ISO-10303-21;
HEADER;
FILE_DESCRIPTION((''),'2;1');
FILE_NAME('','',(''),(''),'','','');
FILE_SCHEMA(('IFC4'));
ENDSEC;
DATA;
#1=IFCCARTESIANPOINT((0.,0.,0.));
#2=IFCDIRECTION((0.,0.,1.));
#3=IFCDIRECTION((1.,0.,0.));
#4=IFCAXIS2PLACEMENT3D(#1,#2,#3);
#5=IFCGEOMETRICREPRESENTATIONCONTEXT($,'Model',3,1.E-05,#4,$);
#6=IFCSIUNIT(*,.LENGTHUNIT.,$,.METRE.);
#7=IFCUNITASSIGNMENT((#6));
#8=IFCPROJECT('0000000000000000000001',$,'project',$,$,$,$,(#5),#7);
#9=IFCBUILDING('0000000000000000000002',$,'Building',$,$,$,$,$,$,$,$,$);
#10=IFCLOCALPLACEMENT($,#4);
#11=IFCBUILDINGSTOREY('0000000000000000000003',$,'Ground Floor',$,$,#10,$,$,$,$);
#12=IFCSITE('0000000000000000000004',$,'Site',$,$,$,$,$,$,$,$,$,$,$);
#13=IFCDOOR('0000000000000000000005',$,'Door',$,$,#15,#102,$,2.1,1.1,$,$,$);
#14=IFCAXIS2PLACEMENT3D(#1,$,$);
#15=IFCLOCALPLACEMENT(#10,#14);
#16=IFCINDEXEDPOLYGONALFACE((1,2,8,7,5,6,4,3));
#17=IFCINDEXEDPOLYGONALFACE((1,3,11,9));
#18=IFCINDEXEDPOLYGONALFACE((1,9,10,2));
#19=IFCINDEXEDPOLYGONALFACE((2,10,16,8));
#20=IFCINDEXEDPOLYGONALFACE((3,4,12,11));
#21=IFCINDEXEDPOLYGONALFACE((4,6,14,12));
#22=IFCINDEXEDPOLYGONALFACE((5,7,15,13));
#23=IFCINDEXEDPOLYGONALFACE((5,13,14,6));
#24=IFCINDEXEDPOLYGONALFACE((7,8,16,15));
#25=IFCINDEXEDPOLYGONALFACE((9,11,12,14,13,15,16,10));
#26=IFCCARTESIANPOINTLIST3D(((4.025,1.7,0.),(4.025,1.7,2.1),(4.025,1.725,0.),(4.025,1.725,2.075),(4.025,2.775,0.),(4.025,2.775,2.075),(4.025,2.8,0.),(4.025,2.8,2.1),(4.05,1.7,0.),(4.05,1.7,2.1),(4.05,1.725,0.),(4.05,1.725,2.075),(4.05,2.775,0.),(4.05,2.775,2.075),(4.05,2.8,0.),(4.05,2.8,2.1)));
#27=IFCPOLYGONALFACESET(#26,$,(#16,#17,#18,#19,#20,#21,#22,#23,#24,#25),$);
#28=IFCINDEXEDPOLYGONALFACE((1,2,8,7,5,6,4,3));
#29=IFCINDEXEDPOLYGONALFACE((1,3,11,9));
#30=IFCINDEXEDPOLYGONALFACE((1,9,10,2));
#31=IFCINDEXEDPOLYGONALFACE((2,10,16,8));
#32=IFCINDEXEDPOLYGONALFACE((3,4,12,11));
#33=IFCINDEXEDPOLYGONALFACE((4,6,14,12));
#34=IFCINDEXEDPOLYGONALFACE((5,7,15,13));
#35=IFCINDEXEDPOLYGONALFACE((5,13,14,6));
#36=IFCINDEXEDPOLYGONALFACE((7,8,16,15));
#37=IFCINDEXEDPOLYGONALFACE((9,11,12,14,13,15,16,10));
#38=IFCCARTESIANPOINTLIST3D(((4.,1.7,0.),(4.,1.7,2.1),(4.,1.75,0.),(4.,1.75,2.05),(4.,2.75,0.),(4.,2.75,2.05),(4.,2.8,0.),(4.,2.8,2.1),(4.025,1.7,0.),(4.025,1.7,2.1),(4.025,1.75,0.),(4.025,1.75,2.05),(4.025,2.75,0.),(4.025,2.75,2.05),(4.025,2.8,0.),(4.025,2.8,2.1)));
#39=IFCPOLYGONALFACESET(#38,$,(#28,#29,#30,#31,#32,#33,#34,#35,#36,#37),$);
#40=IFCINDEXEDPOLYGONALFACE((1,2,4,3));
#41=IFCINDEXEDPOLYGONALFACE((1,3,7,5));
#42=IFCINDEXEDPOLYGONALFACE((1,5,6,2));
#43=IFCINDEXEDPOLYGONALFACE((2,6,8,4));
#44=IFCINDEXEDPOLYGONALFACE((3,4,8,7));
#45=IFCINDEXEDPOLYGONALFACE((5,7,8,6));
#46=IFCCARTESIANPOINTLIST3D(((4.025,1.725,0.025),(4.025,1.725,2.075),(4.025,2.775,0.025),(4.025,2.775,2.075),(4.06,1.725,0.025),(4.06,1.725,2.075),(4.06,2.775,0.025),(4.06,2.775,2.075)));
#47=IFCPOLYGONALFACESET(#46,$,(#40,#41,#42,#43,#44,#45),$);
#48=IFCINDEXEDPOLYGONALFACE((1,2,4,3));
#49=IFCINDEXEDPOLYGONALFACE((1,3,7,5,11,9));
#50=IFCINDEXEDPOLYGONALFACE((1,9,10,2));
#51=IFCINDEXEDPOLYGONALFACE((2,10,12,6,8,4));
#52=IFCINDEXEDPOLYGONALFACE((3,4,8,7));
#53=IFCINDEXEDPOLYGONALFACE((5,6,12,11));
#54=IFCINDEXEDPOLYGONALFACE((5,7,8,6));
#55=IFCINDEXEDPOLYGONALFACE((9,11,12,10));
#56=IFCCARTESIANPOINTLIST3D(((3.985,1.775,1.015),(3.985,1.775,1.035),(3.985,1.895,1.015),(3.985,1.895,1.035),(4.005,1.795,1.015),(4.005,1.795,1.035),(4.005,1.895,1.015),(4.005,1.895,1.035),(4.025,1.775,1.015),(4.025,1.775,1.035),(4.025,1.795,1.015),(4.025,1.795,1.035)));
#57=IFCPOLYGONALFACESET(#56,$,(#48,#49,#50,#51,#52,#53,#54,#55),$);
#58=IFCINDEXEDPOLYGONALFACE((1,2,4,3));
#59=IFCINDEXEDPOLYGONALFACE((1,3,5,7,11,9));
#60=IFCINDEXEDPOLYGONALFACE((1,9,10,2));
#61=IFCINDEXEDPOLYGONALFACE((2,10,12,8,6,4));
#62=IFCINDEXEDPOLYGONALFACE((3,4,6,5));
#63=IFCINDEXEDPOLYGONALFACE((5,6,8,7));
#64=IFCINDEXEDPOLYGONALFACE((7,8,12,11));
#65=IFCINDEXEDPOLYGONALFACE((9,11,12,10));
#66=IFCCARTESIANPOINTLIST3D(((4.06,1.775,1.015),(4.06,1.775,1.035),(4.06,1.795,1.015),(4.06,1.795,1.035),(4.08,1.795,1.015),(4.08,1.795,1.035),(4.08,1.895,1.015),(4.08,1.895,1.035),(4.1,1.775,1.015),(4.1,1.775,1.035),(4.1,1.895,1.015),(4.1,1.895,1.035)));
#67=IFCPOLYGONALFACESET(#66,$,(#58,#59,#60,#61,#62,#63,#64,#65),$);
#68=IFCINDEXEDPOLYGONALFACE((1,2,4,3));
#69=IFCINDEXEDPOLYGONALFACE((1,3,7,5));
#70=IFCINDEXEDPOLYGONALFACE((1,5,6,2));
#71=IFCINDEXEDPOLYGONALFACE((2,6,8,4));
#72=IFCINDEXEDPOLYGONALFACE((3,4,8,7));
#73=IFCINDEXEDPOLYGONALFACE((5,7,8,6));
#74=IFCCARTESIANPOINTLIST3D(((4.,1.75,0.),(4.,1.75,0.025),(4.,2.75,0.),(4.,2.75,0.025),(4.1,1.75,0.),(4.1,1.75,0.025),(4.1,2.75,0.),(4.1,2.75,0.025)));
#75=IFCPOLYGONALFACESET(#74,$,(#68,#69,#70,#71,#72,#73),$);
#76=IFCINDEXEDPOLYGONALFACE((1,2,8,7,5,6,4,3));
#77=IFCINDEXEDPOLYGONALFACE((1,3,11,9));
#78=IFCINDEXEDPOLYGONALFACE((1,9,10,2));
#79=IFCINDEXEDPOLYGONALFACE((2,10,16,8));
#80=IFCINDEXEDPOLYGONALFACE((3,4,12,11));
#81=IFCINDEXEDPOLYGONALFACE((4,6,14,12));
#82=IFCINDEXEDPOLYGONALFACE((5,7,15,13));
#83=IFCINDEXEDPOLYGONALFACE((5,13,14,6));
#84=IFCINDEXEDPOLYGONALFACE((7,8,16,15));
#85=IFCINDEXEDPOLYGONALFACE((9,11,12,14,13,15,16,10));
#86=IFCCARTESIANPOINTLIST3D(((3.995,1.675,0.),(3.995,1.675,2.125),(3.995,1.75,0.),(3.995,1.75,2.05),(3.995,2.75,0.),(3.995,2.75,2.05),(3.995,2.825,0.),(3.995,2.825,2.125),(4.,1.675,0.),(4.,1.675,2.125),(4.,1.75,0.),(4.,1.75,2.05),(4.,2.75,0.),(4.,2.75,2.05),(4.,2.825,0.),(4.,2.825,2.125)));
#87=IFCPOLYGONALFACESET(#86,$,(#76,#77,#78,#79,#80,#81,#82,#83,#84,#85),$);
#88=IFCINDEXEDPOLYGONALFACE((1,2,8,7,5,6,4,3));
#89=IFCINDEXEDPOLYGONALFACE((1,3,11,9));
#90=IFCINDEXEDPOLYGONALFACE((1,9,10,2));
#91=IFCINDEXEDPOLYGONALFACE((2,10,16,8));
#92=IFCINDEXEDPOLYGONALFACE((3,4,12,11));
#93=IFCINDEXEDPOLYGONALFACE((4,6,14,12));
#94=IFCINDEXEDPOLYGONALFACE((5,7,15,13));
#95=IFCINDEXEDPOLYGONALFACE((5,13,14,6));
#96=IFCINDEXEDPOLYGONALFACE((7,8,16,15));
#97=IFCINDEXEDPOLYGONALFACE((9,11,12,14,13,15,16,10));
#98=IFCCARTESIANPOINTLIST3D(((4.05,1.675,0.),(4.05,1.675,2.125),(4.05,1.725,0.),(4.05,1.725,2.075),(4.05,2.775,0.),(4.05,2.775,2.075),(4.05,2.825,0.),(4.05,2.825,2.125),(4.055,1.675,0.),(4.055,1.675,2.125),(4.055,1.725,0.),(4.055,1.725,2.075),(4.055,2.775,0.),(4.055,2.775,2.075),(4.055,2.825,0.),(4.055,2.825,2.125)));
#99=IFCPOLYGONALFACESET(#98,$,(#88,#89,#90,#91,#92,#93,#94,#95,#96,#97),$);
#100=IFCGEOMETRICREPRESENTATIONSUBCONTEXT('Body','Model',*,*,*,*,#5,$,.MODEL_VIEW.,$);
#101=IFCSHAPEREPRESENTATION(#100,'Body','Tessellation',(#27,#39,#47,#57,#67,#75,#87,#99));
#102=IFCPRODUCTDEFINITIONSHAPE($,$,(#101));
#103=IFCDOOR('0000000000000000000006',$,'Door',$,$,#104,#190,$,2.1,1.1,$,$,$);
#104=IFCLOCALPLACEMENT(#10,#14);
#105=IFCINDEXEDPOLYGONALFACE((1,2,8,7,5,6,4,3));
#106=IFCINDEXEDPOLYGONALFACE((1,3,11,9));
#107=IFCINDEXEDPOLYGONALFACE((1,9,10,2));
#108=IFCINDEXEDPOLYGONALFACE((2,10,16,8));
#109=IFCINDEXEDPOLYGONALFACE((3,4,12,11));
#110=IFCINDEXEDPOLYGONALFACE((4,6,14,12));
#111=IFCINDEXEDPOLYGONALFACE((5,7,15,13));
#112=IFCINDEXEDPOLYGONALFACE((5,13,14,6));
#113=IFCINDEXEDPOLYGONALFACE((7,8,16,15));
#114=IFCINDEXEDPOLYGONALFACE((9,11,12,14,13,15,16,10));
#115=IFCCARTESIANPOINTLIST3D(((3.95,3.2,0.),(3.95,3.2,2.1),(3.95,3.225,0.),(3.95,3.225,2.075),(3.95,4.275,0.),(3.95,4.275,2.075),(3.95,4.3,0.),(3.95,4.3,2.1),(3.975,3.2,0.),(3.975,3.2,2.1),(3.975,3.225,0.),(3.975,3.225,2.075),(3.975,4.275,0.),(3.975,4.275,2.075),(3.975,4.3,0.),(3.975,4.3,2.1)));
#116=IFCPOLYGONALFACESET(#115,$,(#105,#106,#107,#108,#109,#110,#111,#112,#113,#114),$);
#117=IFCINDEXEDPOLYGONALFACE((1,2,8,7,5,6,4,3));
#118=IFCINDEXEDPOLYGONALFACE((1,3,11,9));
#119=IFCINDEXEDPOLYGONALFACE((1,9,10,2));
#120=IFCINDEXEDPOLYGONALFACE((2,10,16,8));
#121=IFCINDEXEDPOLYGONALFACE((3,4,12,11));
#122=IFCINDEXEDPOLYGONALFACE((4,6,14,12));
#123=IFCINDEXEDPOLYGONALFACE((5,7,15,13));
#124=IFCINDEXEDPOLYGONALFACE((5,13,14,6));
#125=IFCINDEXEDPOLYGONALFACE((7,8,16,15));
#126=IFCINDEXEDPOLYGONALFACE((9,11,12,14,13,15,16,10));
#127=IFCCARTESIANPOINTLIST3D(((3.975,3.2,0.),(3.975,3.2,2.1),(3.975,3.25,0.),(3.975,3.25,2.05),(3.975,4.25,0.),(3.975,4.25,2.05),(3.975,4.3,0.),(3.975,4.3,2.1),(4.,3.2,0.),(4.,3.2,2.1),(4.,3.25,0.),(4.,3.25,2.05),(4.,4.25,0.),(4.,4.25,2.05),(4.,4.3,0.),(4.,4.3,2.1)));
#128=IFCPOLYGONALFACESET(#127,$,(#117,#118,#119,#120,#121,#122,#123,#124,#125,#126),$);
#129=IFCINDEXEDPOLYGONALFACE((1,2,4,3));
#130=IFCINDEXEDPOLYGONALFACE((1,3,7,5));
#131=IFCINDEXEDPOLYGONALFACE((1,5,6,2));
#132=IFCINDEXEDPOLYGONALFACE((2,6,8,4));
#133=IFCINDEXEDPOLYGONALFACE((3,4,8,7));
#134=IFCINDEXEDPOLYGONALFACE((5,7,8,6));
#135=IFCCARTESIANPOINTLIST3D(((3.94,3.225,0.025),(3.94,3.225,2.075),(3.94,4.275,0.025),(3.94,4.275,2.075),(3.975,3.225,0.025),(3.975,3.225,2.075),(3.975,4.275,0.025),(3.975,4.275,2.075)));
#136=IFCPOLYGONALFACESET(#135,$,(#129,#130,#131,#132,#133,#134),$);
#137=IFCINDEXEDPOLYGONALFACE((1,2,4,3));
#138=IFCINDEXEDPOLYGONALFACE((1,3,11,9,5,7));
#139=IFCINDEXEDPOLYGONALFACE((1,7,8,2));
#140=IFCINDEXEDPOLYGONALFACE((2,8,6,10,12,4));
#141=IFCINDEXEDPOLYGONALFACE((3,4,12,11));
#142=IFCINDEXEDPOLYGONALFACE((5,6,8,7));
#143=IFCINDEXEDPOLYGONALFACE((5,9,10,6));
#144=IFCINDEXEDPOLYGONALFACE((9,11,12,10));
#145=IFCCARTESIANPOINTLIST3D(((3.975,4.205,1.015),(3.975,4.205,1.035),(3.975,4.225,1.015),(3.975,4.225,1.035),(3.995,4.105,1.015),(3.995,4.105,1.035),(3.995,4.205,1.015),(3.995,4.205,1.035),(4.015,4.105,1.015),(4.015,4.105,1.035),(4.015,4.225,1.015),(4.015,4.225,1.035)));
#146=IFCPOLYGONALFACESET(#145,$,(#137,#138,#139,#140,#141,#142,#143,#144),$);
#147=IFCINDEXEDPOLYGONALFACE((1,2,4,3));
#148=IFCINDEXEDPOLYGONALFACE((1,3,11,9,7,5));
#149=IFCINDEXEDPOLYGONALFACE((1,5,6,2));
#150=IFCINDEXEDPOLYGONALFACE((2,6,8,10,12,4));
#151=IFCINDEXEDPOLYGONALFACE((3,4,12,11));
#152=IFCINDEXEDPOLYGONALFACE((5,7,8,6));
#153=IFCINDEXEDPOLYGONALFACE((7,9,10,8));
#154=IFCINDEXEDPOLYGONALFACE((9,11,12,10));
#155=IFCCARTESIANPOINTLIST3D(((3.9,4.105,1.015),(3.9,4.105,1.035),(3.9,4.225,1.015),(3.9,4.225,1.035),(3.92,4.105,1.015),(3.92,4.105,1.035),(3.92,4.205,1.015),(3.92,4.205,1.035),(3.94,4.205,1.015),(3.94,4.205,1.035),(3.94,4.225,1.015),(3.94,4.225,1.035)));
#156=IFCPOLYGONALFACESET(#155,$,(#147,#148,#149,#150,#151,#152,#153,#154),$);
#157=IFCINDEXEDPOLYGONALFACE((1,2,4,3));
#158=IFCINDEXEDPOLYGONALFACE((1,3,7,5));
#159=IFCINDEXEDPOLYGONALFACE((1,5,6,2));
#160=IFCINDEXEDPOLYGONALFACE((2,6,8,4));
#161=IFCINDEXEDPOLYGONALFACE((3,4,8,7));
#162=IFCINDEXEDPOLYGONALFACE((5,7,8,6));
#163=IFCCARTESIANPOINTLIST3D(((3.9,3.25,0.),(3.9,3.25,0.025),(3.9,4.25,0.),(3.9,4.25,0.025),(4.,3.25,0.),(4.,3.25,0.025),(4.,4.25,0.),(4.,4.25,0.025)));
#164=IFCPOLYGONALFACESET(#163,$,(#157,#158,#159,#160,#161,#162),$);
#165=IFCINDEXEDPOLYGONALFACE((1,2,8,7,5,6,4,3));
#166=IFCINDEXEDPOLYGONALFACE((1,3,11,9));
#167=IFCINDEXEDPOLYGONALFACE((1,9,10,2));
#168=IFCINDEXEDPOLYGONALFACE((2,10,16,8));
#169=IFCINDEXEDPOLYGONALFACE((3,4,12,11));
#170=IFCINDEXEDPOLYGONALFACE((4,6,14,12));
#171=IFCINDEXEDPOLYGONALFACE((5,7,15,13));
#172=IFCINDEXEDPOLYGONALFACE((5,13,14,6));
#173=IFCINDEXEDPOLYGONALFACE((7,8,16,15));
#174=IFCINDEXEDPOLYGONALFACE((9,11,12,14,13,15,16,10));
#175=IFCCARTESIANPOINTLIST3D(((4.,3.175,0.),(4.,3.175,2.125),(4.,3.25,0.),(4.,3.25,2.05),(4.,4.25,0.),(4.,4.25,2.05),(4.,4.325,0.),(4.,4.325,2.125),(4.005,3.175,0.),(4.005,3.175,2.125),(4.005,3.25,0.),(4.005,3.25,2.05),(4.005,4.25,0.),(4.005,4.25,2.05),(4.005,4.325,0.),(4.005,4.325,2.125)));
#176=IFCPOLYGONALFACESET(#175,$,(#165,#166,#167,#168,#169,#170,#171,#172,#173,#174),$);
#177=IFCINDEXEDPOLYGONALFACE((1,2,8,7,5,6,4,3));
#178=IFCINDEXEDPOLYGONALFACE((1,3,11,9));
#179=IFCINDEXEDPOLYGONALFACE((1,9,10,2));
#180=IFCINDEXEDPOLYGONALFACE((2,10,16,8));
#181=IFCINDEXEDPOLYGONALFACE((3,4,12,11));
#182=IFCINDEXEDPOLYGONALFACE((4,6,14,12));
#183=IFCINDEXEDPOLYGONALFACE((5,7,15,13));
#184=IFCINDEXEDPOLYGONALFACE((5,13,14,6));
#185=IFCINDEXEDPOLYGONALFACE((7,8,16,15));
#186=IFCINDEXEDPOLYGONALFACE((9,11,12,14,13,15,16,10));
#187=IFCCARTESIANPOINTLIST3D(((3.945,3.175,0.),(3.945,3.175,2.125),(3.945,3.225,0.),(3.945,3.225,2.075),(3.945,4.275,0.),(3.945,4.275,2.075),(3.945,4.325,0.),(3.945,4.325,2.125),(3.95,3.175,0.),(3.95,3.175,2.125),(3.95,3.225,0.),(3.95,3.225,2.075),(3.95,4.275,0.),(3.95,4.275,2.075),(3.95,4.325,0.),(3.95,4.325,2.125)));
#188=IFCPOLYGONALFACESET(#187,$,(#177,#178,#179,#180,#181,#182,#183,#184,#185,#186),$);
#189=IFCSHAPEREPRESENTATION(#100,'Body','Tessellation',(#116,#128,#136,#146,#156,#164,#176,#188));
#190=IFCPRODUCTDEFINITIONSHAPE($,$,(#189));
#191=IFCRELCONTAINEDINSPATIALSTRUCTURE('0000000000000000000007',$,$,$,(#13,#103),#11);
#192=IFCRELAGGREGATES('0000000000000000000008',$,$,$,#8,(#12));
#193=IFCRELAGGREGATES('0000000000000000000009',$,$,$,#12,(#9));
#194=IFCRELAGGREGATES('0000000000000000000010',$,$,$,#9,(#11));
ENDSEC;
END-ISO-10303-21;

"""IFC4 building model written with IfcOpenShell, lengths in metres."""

from ifc_helpers import new_model, si_unit, frame, origin_with_axes, place, context, subcontext, project, spatial, line, indexed_curve, outline, extrude, element, save


model = new_model("IFC4")

# Units and contexts
model_context = context("Model", 3, precision=1e-05, world=origin_with_axes())
body_context = subcontext(model_context, "Body", "Model", "MODEL_VIEW")
ifc_project = project(units=[si_unit("LENGTHUNIT", "METRE")], contexts=[model_context])

# Site, building, storey
site = spatial("IfcSite", under=ifc_project, Name="Site")
building = spatial("IfcBuilding", under=site, Name="Building")
storey_placement = place(None, origin_with_axes())
storey = spatial("IfcBuildingStorey", under=building, at=storey_placement, Name="Ground Floor")

# Doors
door_1_placement = place(storey_placement, frame((4.0, 2.8, 0.0), z_axis=(0.0, 0.0, 1.0), x_axis=(0.0, -1.0, 0.0)))
element("IfcDoor", 1, at=door_1_placement, inside=storey, Name="Door", OverallHeight=2.1, OverallWidth=1.1, context=body_context, shape_type="SweptSolid", body=[
    extrude(outline(indexed_curve([(0.0, 0.0), (0.0, 2.1), (1.1, 2.1), (1.1, 0.0), (1.075, 0.0), (1.075, 2.075), (0.025, 2.075), (0.025, 0.0)], segments=[line(1, 2, 3, 4, 5, 6, 7, 8, 1)])), frame((0.0, 0.025, 0.0), z_axis=(0.0, -1.0, 0.0), x_axis=(1.0, 0.0, 0.0)), (0.0, 0.0, -1.0), 0.025),
    extrude(outline(indexed_curve([(0.0, 0.0), (0.0, 2.1), (1.1, 2.1), (1.1, 0.0), (1.05, 0.0), (1.05, 2.05), (0.05, 2.05), (0.05, 0.0)], segments=[line(1, 2, 3, 4, 5, 6, 7, 8, 1)])), frame((0.0, 0.0, 0.0), z_axis=(0.0, -1.0, 0.0), x_axis=(1.0, 0.0, 0.0)), (0.0, 0.0, -1.0), 0.025),
    extrude(outline(indexed_curve([(0.0, 0.0), (1.05, 0.0), (1.05, 0.035), (0.0, 0.035)], segments=[line(1, 2, 3, 4, 1)])), frame((0.025, 0.025, 0.025), z_axis=(0.0, 0.0, 1.0), x_axis=(1.0, 0.0, 0.0)), (0.0, 0.0, 1.0), 2.05),
    extrude(outline(indexed_curve([(0.0, 0.0), (0.0, -0.04), (-0.12, -0.04), (-0.12, -0.02), (-0.02, -0.02), (-0.02, 0.0)], segments=[line(1, 2, 3, 4, 5, 6, 1)])), frame((1.025, 0.025, 1.015), z_axis=(0.0, 0.0, 1.0), x_axis=(1.0, 0.0, 0.0)), (0.0, 0.0, 1.0), 0.02),
    extrude(outline(indexed_curve([(0.0, 0.0), (0.0, 0.04), (-0.12, 0.04), (-0.12, 0.02), (-0.02, 0.02), (-0.02, 0.0)], segments=[line(1, 2, 3, 4, 5, 6, 1)])), frame((1.025, 0.06, 1.015), z_axis=(0.0, 0.0, 1.0), x_axis=(1.0, 0.0, 0.0)), (0.0, 0.0, 1.0), 0.02),
    extrude(outline(indexed_curve([(0.0, 0.0), (1.0, 0.0), (1.0, 0.1), (0.0, 0.1)], segments=[line(1, 2, 3, 4, 1)])), frame((0.05, 0.0, 0.0), z_axis=(0.0, 0.0, 1.0), x_axis=(1.0, 0.0, 0.0)), (0.0, 0.0, 1.0), 0.025),
    extrude(outline(indexed_curve([(0.0, 0.0), (0.0, 2.125), (1.15, 2.125), (1.15, 0.0), (1.075, 0.0), (1.075, 2.05), (0.075, 2.05), (0.075, 0.0)], segments=[line(1, 2, 3, 4, 5, 6, 7, 8, 1)])), frame((-0.025, -0.005, 0.0), z_axis=(0.0, -1.0, 0.0), x_axis=(1.0, 0.0, 0.0)), (0.0, 0.0, -1.0), 0.005),
    extrude(outline(indexed_curve([(0.0, 0.0), (0.0, 2.125), (1.15, 2.125), (1.15, 0.0), (1.1, 0.0), (1.1, 2.075), (0.05, 2.075), (0.05, 0.0)], segments=[line(1, 2, 3, 4, 5, 6, 7, 8, 1)])), frame((-0.025, 0.05, 0.0), z_axis=(0.0, -1.0, 0.0), x_axis=(1.0, 0.0, 0.0)), (0.0, 0.0, -1.0), 0.005),
])
door_2_placement = place(storey_placement, frame((4.0, 3.2, 0.0), z_axis=(0.0, 0.0, 1.0), x_axis=(0.0, 1.0, 0.0)))
element("IfcDoor", 2, at=door_2_placement, inside=storey, Name="Door", OverallHeight=2.1, OverallWidth=1.1, context=body_context, shape_type="SweptSolid", body=[
    extrude(outline(indexed_curve([(0.0, 0.0), (0.0, 2.1), (1.1, 2.1), (1.1, 0.0), (1.075, 0.0), (1.075, 2.075), (0.025, 2.075), (0.025, 0.0)], segments=[line(1, 2, 3, 4, 5, 6, 7, 8, 1)])), frame((0.0, 0.025, 0.0), z_axis=(0.0, -1.0, 0.0), x_axis=(1.0, 0.0, 0.0)), (0.0, 0.0, -1.0), 0.025),
    extrude(outline(indexed_curve([(0.0, 0.0), (0.0, 2.1), (1.1, 2.1), (1.1, 0.0), (1.05, 0.0), (1.05, 2.05), (0.05, 2.05), (0.05, 0.0)], segments=[line(1, 2, 3, 4, 5, 6, 7, 8, 1)])), frame((0.0, 0.0, 0.0), z_axis=(0.0, -1.0, 0.0), x_axis=(1.0, 0.0, 0.0)), (0.0, 0.0, -1.0), 0.025),
    extrude(outline(indexed_curve([(0.0, 0.0), (1.05, 0.0), (1.05, 0.035), (0.0, 0.035)], segments=[line(1, 2, 3, 4, 1)])), frame((0.025, 0.025, 0.025), z_axis=(0.0, 0.0, 1.0), x_axis=(1.0, 0.0, 0.0)), (0.0, 0.0, 1.0), 2.05),
    extrude(outline(indexed_curve([(0.0, 0.0), (0.0, -0.04), (-0.12, -0.04), (-0.12, -0.02), (-0.02, -0.02), (-0.02, 0.0)], segments=[line(1, 2, 3, 4, 5, 6, 1)])), frame((1.025, 0.025, 1.015), z_axis=(0.0, 0.0, 1.0), x_axis=(1.0, 0.0, 0.0)), (0.0, 0.0, 1.0), 0.02),
    extrude(outline(indexed_curve([(0.0, 0.0), (0.0, 0.04), (-0.12, 0.04), (-0.12, 0.02), (-0.02, 0.02), (-0.02, 0.0)], segments=[line(1, 2, 3, 4, 5, 6, 1)])), frame((1.025, 0.06, 1.015), z_axis=(0.0, 0.0, 1.0), x_axis=(1.0, 0.0, 0.0)), (0.0, 0.0, 1.0), 0.02),
    extrude(outline(indexed_curve([(0.0, 0.0), (1.0, 0.0), (1.0, 0.1), (0.0, 0.1)], segments=[line(1, 2, 3, 4, 1)])), frame((0.05, 0.0, 0.0), z_axis=(0.0, 0.0, 1.0), x_axis=(1.0, 0.0, 0.0)), (0.0, 0.0, 1.0), 0.025),
    extrude(outline(indexed_curve([(0.0, 0.0), (0.0, 2.125), (1.15, 2.125), (1.15, 0.0), (1.075, 0.0), (1.075, 2.05), (0.075, 2.05), (0.075, 0.0)], segments=[line(1, 2, 3, 4, 5, 6, 7, 8, 1)])), frame((-0.025, -0.005, 0.0), z_axis=(0.0, -1.0, 0.0), x_axis=(1.0, 0.0, 0.0)), (0.0, 0.0, -1.0), 0.005),
    extrude(outline(indexed_curve([(0.0, 0.0), (0.0, 2.125), (1.15, 2.125), (1.15, 0.0), (1.1, 0.0), (1.1, 2.075), (0.05, 2.075), (0.05, 0.0)], segments=[line(1, 2, 3, 4, 5, 6, 7, 8, 1)])), frame((-0.025, 0.05, 0.0), z_axis=(0.0, -1.0, 0.0), x_axis=(1.0, 0.0, 0.0)), (0.0, 0.0, -1.0), 0.005),
])

save(model, "model.ifc")
